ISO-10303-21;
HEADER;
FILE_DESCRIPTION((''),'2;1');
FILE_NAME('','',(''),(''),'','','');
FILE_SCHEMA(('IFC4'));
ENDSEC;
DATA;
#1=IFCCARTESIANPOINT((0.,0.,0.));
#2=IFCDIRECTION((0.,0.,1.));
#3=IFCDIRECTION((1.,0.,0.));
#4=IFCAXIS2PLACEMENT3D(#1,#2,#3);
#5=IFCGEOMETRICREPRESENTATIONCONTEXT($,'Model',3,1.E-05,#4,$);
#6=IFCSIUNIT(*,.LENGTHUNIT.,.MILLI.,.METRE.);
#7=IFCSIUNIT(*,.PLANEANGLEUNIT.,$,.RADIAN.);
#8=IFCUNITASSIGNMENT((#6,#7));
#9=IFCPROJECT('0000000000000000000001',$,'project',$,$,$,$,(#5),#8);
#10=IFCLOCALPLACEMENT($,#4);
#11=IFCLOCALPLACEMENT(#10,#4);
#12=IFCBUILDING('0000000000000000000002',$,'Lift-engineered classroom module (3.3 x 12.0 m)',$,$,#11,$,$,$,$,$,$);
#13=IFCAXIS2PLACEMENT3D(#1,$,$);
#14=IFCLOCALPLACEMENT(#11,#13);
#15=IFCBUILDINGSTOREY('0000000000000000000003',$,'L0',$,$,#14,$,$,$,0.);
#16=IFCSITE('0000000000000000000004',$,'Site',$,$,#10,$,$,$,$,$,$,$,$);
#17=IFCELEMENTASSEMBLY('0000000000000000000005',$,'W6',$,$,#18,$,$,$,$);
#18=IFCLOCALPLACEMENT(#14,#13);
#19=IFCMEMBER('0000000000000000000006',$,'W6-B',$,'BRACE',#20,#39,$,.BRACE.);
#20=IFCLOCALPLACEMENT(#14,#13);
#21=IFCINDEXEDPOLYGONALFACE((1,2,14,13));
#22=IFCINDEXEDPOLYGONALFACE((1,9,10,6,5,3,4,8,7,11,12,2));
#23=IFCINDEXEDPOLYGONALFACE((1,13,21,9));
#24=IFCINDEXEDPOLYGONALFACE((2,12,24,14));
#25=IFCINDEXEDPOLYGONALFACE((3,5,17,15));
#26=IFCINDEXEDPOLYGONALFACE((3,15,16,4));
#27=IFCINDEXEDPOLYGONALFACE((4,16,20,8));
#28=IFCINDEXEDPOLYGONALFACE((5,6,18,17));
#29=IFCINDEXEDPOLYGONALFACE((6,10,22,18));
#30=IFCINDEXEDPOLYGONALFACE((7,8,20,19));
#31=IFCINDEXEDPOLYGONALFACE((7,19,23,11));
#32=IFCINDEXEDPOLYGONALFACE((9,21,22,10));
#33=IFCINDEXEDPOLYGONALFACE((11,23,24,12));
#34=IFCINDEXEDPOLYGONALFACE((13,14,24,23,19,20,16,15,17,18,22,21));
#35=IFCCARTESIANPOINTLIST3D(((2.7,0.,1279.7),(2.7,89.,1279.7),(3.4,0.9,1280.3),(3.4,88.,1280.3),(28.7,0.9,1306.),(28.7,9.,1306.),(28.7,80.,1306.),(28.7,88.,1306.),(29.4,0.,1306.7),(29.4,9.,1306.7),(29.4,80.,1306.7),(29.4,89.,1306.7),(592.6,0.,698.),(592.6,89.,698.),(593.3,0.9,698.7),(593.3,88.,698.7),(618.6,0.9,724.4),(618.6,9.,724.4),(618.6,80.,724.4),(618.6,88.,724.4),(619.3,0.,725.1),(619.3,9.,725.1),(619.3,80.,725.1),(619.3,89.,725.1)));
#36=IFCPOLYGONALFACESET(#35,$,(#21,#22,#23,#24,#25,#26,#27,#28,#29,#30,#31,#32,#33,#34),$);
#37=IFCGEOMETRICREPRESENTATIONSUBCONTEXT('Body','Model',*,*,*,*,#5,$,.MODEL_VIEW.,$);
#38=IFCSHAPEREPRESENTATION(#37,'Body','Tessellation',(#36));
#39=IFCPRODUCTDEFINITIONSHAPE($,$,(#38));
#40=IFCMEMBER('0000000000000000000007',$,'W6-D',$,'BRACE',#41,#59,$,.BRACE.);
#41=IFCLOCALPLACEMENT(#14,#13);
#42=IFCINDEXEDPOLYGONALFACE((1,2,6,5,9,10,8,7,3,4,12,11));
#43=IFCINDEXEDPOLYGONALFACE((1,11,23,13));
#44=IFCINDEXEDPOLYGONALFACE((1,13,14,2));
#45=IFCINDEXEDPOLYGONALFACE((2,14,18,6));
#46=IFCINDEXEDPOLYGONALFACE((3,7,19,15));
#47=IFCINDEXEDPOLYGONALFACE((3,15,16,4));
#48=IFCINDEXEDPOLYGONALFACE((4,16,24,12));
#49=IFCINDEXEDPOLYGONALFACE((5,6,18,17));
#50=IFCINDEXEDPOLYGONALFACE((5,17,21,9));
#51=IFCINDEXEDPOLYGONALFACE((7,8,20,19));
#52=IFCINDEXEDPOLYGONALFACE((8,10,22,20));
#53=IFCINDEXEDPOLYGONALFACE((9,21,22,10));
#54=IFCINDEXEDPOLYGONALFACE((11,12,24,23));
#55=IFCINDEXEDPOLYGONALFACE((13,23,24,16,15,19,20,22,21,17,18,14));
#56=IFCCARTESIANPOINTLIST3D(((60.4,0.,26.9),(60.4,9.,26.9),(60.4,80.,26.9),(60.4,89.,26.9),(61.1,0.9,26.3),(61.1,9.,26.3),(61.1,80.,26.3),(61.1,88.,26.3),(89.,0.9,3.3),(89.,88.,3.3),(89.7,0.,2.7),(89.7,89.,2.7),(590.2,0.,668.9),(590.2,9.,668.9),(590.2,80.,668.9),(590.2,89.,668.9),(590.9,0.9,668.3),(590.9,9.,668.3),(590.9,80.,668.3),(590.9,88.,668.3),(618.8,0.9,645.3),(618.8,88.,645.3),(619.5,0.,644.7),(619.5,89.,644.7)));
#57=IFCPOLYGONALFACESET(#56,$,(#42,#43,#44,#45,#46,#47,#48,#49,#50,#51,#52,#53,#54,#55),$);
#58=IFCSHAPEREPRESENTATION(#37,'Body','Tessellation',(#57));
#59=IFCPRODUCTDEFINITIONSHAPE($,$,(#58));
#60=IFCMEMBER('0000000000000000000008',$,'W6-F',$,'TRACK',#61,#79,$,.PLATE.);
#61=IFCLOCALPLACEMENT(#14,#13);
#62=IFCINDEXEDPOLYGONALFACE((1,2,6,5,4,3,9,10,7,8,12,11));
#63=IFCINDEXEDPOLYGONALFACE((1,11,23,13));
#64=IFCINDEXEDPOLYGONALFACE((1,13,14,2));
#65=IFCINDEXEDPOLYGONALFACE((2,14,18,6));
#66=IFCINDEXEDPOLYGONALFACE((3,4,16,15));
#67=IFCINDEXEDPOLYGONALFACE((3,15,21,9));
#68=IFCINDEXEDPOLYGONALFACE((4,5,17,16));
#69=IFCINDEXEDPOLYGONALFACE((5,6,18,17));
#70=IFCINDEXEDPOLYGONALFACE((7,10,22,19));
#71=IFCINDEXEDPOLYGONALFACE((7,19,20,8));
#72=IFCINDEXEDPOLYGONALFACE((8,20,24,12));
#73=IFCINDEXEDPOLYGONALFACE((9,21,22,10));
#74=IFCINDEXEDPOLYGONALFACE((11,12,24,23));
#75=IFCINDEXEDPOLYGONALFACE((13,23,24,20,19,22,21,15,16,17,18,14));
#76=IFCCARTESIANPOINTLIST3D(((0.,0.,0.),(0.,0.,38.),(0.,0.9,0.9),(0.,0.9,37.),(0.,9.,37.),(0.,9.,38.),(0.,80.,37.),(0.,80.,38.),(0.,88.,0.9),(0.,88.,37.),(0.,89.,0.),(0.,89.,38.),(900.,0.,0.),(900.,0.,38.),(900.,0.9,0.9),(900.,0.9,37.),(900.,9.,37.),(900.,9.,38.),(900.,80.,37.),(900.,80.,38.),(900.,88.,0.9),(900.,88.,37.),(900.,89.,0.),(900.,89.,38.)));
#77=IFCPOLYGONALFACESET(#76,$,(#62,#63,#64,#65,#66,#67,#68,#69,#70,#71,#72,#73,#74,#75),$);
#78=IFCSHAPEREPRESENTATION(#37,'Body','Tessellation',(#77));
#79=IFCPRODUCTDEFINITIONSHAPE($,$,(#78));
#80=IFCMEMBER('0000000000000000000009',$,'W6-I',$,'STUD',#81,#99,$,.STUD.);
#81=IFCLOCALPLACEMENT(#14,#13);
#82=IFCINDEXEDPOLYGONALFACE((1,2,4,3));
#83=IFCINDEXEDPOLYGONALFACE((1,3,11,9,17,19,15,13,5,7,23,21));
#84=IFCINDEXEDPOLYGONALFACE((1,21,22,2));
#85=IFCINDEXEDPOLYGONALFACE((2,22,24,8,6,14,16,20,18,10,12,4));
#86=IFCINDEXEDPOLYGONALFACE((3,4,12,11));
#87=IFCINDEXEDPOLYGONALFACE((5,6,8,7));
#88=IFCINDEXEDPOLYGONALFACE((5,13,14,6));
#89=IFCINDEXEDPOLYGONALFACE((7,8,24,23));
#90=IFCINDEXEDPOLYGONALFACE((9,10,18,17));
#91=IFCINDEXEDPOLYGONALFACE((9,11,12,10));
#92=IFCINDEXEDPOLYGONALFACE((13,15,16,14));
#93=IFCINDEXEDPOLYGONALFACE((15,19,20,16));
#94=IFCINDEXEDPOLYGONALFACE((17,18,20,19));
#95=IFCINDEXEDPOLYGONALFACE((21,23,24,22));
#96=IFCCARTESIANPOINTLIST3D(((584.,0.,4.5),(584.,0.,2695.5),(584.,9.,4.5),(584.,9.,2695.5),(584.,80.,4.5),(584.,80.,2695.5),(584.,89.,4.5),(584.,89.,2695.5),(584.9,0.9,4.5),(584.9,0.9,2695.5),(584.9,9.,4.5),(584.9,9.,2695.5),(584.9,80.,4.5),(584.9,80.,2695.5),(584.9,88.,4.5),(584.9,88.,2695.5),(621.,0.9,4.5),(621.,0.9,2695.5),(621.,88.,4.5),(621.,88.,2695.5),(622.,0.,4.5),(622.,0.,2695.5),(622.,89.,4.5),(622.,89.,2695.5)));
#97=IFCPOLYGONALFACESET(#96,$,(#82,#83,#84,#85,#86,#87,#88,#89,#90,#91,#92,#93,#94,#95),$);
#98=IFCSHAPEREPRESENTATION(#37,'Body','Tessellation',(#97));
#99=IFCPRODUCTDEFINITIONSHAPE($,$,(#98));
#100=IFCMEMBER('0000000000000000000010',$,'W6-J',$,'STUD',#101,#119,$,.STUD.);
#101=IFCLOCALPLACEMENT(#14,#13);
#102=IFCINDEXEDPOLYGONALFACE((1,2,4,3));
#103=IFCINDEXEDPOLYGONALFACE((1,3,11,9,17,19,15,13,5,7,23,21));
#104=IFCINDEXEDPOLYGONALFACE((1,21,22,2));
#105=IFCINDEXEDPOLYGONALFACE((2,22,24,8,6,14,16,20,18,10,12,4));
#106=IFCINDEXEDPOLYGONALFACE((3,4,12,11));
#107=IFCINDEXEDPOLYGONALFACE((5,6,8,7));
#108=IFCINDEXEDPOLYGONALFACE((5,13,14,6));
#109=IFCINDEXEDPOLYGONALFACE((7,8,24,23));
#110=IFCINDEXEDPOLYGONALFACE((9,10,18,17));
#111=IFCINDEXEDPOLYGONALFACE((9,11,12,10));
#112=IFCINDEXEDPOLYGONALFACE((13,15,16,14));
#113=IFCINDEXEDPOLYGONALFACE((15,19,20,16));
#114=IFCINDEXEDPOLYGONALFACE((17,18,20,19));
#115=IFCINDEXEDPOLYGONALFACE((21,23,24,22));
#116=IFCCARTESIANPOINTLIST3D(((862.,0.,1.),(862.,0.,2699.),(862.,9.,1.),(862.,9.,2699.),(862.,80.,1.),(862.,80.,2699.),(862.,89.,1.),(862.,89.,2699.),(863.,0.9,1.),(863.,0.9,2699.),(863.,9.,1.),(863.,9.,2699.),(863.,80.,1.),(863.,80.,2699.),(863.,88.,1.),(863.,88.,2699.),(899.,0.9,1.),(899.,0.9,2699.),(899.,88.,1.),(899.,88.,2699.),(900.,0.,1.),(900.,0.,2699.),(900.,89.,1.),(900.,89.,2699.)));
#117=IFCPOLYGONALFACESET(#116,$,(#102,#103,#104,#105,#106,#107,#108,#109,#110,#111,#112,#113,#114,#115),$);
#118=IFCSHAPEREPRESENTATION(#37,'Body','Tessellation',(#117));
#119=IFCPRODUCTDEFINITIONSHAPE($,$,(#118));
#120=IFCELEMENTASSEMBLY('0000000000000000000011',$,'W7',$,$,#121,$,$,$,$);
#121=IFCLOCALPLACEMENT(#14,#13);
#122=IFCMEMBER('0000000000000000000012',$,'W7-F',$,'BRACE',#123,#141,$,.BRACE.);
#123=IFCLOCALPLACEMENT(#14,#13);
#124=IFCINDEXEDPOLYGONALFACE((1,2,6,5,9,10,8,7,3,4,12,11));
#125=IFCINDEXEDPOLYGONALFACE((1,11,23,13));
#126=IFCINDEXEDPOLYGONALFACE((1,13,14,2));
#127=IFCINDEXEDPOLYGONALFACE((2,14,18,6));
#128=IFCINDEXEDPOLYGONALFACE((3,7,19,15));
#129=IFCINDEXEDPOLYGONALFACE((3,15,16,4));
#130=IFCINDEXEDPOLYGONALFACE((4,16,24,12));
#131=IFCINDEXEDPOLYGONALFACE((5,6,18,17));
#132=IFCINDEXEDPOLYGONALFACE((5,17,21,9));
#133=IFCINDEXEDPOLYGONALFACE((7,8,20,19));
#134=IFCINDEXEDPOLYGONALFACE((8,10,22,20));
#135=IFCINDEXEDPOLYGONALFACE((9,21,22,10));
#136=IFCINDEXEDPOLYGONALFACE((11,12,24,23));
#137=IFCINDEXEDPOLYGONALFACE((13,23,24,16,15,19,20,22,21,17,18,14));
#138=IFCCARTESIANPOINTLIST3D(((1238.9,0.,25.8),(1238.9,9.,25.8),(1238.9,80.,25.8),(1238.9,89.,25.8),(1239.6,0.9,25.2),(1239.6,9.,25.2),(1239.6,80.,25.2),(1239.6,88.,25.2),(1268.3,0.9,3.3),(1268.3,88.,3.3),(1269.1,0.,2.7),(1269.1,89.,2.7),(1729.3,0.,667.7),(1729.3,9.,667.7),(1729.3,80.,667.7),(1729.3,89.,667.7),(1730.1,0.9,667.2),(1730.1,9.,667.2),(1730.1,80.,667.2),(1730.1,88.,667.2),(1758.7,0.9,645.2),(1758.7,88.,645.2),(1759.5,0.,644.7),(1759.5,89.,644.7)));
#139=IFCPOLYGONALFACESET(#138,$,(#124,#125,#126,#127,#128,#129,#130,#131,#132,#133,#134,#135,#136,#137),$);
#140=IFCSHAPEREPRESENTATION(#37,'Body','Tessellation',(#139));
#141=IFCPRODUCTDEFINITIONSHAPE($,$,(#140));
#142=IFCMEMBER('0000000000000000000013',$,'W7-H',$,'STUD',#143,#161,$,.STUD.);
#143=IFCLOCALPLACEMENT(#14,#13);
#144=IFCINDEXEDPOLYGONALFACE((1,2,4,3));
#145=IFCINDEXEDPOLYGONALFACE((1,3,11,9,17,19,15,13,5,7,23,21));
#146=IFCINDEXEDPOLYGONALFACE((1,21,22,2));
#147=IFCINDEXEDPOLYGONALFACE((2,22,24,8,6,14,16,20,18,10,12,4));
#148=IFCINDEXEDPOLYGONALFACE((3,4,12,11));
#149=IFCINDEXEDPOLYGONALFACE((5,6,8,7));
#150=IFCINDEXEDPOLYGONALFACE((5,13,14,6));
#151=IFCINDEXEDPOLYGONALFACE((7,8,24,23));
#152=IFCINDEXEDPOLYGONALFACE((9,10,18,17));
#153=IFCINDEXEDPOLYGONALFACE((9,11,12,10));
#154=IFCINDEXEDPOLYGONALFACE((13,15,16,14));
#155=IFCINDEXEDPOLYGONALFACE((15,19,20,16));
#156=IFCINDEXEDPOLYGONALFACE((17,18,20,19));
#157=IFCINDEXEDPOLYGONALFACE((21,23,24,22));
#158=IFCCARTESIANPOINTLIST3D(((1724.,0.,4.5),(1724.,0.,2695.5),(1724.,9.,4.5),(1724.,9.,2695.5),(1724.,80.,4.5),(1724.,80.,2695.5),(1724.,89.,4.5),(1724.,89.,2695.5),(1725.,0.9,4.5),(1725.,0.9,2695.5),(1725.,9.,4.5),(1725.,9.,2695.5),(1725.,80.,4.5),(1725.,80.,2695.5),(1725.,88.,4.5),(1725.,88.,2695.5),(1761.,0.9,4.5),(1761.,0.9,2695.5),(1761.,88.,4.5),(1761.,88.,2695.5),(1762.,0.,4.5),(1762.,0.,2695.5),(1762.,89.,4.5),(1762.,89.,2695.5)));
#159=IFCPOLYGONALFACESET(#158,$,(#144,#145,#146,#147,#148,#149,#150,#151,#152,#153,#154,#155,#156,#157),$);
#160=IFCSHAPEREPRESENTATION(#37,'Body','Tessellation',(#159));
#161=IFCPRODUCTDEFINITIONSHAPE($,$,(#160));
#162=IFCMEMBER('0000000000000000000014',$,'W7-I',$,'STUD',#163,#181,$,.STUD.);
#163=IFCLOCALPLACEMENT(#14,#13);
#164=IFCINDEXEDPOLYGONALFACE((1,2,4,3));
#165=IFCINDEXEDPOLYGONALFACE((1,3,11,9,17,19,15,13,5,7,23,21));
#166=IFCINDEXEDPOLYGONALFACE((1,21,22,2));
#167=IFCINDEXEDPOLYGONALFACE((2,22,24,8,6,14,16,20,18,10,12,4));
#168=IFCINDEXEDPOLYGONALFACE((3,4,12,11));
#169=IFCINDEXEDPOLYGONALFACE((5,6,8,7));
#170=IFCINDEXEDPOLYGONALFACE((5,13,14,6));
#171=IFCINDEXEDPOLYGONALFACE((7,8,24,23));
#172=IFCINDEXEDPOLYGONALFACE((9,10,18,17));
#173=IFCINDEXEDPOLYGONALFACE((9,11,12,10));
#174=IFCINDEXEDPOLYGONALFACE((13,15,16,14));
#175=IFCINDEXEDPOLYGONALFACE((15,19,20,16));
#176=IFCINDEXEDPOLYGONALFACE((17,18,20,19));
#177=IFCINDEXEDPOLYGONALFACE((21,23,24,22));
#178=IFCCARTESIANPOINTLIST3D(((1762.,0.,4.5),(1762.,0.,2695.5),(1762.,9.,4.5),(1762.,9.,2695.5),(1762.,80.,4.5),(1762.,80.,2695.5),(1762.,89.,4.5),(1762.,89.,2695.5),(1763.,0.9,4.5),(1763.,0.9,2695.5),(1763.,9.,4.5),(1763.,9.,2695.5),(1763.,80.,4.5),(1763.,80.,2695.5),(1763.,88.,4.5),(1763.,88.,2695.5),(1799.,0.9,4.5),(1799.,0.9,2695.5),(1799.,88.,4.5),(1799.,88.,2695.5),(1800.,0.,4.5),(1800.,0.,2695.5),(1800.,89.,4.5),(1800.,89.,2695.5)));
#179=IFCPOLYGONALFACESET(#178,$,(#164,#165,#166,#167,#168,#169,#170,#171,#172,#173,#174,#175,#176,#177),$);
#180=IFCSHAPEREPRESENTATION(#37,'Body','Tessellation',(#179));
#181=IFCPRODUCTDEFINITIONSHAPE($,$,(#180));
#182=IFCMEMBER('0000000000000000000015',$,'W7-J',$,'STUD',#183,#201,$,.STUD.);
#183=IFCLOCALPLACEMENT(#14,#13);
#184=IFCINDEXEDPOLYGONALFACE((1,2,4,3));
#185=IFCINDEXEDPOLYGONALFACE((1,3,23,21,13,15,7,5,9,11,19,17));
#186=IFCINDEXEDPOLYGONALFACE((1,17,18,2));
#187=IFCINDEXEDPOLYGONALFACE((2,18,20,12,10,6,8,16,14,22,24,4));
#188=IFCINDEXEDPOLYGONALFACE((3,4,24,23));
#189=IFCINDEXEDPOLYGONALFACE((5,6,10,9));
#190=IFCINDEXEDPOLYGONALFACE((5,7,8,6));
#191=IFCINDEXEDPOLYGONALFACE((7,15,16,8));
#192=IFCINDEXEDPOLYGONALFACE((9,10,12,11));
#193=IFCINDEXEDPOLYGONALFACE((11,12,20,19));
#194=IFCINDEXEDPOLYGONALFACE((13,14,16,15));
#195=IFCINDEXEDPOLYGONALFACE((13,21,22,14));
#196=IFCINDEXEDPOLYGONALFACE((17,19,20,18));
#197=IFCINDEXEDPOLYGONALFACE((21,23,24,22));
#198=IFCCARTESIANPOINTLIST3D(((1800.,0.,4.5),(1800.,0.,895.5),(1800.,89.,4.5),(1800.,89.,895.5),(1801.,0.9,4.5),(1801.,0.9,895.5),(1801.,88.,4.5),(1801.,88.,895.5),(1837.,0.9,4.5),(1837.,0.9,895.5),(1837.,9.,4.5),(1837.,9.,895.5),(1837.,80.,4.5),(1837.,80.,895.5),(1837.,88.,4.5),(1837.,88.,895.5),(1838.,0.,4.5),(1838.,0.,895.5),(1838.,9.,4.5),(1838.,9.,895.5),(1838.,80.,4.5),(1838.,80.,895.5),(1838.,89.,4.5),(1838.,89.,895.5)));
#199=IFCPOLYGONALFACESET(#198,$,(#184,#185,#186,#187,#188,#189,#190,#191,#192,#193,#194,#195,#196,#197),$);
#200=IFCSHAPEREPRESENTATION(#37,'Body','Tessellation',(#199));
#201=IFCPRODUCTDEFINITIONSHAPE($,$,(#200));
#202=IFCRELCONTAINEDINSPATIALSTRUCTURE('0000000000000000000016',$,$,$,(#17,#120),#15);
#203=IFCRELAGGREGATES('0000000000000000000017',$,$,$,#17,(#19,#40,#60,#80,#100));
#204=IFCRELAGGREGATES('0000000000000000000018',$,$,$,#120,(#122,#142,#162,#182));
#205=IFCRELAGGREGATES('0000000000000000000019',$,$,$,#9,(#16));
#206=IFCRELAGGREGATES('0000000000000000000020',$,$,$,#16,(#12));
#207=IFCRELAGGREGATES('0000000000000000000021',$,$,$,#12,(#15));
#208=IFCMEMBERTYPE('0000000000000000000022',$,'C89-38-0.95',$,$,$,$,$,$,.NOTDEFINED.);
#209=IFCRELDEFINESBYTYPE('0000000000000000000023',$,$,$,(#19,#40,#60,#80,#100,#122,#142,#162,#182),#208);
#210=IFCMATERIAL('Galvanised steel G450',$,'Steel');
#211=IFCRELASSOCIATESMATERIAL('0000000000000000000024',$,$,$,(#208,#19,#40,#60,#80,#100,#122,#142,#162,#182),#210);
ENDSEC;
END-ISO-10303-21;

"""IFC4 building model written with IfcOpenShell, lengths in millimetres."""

from ifc_helpers import new_model, si_unit, frame, origin, origin_with_axes, origin_2d, place, context, subcontext, project, spatial, c_section, extrude, material, material_profile, profile_set, profile_usage, type_object, element, aggregate, save


model = new_model("IFC4")

# Units and contexts
model_context = context("Model", 3, precision=1e-05, world=origin_with_axes())
body_context = subcontext(model_context, "Body", "Model", "MODEL_VIEW")
ifc_project = project(units=[si_unit("LENGTHUNIT", "METRE", prefix="MILLI"), si_unit("PLANEANGLEUNIT", "RADIAN")], contexts=[model_context])

# Site, building, storey
site_placement = place(None, origin_with_axes())
site = spatial("IfcSite", under=ifc_project, at=site_placement, Name="Site")
building_placement = place(site_placement, origin_with_axes())
building = spatial("IfcBuilding", under=site, at=building_placement, Name="Lift-engineered classroom module (3.3 x 12.0 m)")
storey_placement = place(building_placement, origin())
storey = spatial("IfcBuildingStorey", under=building, at=storey_placement, Name="L0", Elevation=0.0)

# Element assemblies, members
assembly_1_placement = place(storey_placement, frame((0.0, 44.5, 0.0)))
assembly_1 = element("IfcElementAssembly", 1, at=assembly_1_placement, inside=storey, Name="W6")
ifc_material = material(Name="Galvanised steel G450", Category="Steel")
ifc_material_profile = material_profile(ifc_material, c_section(Depth=89.0, Width=38.0, WallThickness=0.9, Girth=9.0, at=origin_2d()), Name="C89-38-0.95")
ifc_profile_set = profile_set([ifc_material_profile], Name="C89-38-0.95")
ifc_profile_usage = profile_usage(ifc_profile_set)
member_type = type_object("IfcMemberType", Name="C89-38-0.95", PredefinedType="NOTDEFINED", material=ifc_profile_set)
member_1_placement = place(assembly_1_placement, frame((16.0, 0.0, 1293.2), z_axis=(0.712068, 0.0, -0.70211), x_axis=(0.70211, 0.0, 0.712068)))
member_1 = element("IfcMember", 2, at=member_1_placement, type_object=member_type, material=ifc_profile_usage, Name="W6-B", ObjectType="BRACE", PredefinedType="BRACE", context=body_context, shape_type="SweptSolid", body=[
    extrude(c_section(Depth=89.0, Width=38.0, WallThickness=0.9, Girth=9.0, at=origin_2d()), origin(), (0.0, 0.0, 1.0), 828.5),
])
member_2_placement = place(assembly_1_placement, frame((75.0, 0.0, 14.8), z_axis=(0.636508, 0.0, 0.77127), x_axis=(-0.77127, 0.0, 0.636508)))
member_2 = element("IfcMember", 3, at=member_2_placement, type_object=member_type, material=ifc_profile_usage, Name="W6-D", ObjectType="BRACE", PredefinedType="BRACE", context=body_context, shape_type="SweptSolid", body=[
    extrude(c_section(Depth=89.0, Width=38.0, WallThickness=0.9, Girth=9.0, at=origin_2d()), origin(), (0.0, 0.0, 1.0), 832.4),
])
member_3_placement = place(assembly_1_placement, frame((0.0, 0.0, 19.0), z_axis=(1.0, 0.0, 0.0), x_axis=(0.0, 0.0, 1.0)))
member_3 = element("IfcMember", 4, at=member_3_placement, type_object=member_type, material=ifc_profile_usage, Name="W6-F", ObjectType="TRACK", PredefinedType="PLATE", context=body_context, shape_type="SweptSolid", body=[
    extrude(c_section(Depth=89.0, Width=38.0, WallThickness=0.9, Girth=9.0, at=origin_2d()), origin(), (0.0, 0.0, 1.0), 900.0),
])
member_4_placement = place(assembly_1_placement, frame((603.0, 0.0, 4.5), z_axis=(0.0, 0.0, 1.0), x_axis=(-1.0, 0.0, 0.0)))
member_4 = element("IfcMember", 5, at=member_4_placement, type_object=member_type, material=ifc_profile_usage, Name="W6-I", ObjectType="STUD", PredefinedType="STUD", context=body_context, shape_type="SweptSolid", body=[
    extrude(c_section(Depth=89.0, Width=38.0, WallThickness=0.9, Girth=9.0, at=origin_2d()), origin(), (0.0, 0.0, 1.0), 2691.0),
])
member_5_placement = place(assembly_1_placement, frame((881.0, 0.0, 0.9), z_axis=(0.0, 0.0, 1.0), x_axis=(-1.0, 0.0, 0.0)))
member_5 = element("IfcMember", 6, at=member_5_placement, type_object=member_type, material=ifc_profile_usage, Name="W6-J", ObjectType="STUD", PredefinedType="STUD", context=body_context, shape_type="SweptSolid", body=[
    extrude(c_section(Depth=89.0, Width=38.0, WallThickness=0.9, Girth=9.0, at=origin_2d()), origin(), (0.0, 0.0, 1.0), 2698.1),
])
aggregate(assembly_1, [member_1, member_2, member_3, member_4, member_5])
assembly_2_placement = place(storey_placement, frame((900.0, 44.5, 0.0)))
assembly_2 = element("IfcElementAssembly", 7, at=assembly_2_placement, inside=storey, Name="W7")
member_6_placement = place(assembly_2_placement, frame((354.0, 0.0, 14.2), z_axis=(0.607061, 0.0, 0.794655), x_axis=(-0.794655, 0.0, 0.607061)))
member_6 = element("IfcMember", 8, at=member_6_placement, type_object=member_type, material=ifc_profile_usage, Name="W7-F", ObjectType="BRACE", PredefinedType="BRACE", context=body_context, shape_type="SweptSolid", body=[
    extrude(c_section(Depth=89.0, Width=38.0, WallThickness=0.9, Girth=9.0, at=origin_2d()), origin(), (0.0, 0.0, 1.0), 807.9),
])
member_7_placement = place(assembly_2_placement, frame((843.0, 0.0, 4.5), z_axis=(0.0, 0.0, 1.0), x_axis=(-1.0, 0.0, 0.0)))
member_7 = element("IfcMember", 9, at=member_7_placement, type_object=member_type, material=ifc_profile_usage, Name="W7-H", ObjectType="STUD", PredefinedType="STUD", context=body_context, shape_type="SweptSolid", body=[
    extrude(c_section(Depth=89.0, Width=38.0, WallThickness=0.9, Girth=9.0, at=origin_2d()), origin(), (0.0, 0.0, 1.0), 2691.0),
])
member_8_placement = place(assembly_2_placement, frame((881.0, 0.0, 4.5), z_axis=(0.0, 0.0, 1.0), x_axis=(-1.0, 0.0, 0.0)))
member_8 = element("IfcMember", 10, at=member_8_placement, type_object=member_type, material=ifc_profile_usage, Name="W7-I", ObjectType="STUD", PredefinedType="STUD", context=body_context, shape_type="SweptSolid", body=[
    extrude(c_section(Depth=89.0, Width=38.0, WallThickness=0.9, Girth=9.0, at=origin_2d()), origin(), (0.0, 0.0, 1.0), 2691.0),
])
member_9_placement = place(assembly_2_placement, frame((919.0, 0.0, 895.5), z_axis=(0.0, 0.0, -1.0), x_axis=(1.0, 0.0, 0.0)))
member_9 = element("IfcMember", 11, at=member_9_placement, type_object=member_type, material=ifc_profile_usage, Name="W7-J", ObjectType="STUD", PredefinedType="STUD", context=body_context, shape_type="SweptSolid", body=[
    extrude(c_section(Depth=89.0, Width=38.0, WallThickness=0.9, Girth=9.0, at=origin_2d()), origin(), (0.0, 0.0, 1.0), 891.0),
])
aggregate(assembly_2, [member_6, member_7, member_8, member_9])

save(model, "model.ifc")
